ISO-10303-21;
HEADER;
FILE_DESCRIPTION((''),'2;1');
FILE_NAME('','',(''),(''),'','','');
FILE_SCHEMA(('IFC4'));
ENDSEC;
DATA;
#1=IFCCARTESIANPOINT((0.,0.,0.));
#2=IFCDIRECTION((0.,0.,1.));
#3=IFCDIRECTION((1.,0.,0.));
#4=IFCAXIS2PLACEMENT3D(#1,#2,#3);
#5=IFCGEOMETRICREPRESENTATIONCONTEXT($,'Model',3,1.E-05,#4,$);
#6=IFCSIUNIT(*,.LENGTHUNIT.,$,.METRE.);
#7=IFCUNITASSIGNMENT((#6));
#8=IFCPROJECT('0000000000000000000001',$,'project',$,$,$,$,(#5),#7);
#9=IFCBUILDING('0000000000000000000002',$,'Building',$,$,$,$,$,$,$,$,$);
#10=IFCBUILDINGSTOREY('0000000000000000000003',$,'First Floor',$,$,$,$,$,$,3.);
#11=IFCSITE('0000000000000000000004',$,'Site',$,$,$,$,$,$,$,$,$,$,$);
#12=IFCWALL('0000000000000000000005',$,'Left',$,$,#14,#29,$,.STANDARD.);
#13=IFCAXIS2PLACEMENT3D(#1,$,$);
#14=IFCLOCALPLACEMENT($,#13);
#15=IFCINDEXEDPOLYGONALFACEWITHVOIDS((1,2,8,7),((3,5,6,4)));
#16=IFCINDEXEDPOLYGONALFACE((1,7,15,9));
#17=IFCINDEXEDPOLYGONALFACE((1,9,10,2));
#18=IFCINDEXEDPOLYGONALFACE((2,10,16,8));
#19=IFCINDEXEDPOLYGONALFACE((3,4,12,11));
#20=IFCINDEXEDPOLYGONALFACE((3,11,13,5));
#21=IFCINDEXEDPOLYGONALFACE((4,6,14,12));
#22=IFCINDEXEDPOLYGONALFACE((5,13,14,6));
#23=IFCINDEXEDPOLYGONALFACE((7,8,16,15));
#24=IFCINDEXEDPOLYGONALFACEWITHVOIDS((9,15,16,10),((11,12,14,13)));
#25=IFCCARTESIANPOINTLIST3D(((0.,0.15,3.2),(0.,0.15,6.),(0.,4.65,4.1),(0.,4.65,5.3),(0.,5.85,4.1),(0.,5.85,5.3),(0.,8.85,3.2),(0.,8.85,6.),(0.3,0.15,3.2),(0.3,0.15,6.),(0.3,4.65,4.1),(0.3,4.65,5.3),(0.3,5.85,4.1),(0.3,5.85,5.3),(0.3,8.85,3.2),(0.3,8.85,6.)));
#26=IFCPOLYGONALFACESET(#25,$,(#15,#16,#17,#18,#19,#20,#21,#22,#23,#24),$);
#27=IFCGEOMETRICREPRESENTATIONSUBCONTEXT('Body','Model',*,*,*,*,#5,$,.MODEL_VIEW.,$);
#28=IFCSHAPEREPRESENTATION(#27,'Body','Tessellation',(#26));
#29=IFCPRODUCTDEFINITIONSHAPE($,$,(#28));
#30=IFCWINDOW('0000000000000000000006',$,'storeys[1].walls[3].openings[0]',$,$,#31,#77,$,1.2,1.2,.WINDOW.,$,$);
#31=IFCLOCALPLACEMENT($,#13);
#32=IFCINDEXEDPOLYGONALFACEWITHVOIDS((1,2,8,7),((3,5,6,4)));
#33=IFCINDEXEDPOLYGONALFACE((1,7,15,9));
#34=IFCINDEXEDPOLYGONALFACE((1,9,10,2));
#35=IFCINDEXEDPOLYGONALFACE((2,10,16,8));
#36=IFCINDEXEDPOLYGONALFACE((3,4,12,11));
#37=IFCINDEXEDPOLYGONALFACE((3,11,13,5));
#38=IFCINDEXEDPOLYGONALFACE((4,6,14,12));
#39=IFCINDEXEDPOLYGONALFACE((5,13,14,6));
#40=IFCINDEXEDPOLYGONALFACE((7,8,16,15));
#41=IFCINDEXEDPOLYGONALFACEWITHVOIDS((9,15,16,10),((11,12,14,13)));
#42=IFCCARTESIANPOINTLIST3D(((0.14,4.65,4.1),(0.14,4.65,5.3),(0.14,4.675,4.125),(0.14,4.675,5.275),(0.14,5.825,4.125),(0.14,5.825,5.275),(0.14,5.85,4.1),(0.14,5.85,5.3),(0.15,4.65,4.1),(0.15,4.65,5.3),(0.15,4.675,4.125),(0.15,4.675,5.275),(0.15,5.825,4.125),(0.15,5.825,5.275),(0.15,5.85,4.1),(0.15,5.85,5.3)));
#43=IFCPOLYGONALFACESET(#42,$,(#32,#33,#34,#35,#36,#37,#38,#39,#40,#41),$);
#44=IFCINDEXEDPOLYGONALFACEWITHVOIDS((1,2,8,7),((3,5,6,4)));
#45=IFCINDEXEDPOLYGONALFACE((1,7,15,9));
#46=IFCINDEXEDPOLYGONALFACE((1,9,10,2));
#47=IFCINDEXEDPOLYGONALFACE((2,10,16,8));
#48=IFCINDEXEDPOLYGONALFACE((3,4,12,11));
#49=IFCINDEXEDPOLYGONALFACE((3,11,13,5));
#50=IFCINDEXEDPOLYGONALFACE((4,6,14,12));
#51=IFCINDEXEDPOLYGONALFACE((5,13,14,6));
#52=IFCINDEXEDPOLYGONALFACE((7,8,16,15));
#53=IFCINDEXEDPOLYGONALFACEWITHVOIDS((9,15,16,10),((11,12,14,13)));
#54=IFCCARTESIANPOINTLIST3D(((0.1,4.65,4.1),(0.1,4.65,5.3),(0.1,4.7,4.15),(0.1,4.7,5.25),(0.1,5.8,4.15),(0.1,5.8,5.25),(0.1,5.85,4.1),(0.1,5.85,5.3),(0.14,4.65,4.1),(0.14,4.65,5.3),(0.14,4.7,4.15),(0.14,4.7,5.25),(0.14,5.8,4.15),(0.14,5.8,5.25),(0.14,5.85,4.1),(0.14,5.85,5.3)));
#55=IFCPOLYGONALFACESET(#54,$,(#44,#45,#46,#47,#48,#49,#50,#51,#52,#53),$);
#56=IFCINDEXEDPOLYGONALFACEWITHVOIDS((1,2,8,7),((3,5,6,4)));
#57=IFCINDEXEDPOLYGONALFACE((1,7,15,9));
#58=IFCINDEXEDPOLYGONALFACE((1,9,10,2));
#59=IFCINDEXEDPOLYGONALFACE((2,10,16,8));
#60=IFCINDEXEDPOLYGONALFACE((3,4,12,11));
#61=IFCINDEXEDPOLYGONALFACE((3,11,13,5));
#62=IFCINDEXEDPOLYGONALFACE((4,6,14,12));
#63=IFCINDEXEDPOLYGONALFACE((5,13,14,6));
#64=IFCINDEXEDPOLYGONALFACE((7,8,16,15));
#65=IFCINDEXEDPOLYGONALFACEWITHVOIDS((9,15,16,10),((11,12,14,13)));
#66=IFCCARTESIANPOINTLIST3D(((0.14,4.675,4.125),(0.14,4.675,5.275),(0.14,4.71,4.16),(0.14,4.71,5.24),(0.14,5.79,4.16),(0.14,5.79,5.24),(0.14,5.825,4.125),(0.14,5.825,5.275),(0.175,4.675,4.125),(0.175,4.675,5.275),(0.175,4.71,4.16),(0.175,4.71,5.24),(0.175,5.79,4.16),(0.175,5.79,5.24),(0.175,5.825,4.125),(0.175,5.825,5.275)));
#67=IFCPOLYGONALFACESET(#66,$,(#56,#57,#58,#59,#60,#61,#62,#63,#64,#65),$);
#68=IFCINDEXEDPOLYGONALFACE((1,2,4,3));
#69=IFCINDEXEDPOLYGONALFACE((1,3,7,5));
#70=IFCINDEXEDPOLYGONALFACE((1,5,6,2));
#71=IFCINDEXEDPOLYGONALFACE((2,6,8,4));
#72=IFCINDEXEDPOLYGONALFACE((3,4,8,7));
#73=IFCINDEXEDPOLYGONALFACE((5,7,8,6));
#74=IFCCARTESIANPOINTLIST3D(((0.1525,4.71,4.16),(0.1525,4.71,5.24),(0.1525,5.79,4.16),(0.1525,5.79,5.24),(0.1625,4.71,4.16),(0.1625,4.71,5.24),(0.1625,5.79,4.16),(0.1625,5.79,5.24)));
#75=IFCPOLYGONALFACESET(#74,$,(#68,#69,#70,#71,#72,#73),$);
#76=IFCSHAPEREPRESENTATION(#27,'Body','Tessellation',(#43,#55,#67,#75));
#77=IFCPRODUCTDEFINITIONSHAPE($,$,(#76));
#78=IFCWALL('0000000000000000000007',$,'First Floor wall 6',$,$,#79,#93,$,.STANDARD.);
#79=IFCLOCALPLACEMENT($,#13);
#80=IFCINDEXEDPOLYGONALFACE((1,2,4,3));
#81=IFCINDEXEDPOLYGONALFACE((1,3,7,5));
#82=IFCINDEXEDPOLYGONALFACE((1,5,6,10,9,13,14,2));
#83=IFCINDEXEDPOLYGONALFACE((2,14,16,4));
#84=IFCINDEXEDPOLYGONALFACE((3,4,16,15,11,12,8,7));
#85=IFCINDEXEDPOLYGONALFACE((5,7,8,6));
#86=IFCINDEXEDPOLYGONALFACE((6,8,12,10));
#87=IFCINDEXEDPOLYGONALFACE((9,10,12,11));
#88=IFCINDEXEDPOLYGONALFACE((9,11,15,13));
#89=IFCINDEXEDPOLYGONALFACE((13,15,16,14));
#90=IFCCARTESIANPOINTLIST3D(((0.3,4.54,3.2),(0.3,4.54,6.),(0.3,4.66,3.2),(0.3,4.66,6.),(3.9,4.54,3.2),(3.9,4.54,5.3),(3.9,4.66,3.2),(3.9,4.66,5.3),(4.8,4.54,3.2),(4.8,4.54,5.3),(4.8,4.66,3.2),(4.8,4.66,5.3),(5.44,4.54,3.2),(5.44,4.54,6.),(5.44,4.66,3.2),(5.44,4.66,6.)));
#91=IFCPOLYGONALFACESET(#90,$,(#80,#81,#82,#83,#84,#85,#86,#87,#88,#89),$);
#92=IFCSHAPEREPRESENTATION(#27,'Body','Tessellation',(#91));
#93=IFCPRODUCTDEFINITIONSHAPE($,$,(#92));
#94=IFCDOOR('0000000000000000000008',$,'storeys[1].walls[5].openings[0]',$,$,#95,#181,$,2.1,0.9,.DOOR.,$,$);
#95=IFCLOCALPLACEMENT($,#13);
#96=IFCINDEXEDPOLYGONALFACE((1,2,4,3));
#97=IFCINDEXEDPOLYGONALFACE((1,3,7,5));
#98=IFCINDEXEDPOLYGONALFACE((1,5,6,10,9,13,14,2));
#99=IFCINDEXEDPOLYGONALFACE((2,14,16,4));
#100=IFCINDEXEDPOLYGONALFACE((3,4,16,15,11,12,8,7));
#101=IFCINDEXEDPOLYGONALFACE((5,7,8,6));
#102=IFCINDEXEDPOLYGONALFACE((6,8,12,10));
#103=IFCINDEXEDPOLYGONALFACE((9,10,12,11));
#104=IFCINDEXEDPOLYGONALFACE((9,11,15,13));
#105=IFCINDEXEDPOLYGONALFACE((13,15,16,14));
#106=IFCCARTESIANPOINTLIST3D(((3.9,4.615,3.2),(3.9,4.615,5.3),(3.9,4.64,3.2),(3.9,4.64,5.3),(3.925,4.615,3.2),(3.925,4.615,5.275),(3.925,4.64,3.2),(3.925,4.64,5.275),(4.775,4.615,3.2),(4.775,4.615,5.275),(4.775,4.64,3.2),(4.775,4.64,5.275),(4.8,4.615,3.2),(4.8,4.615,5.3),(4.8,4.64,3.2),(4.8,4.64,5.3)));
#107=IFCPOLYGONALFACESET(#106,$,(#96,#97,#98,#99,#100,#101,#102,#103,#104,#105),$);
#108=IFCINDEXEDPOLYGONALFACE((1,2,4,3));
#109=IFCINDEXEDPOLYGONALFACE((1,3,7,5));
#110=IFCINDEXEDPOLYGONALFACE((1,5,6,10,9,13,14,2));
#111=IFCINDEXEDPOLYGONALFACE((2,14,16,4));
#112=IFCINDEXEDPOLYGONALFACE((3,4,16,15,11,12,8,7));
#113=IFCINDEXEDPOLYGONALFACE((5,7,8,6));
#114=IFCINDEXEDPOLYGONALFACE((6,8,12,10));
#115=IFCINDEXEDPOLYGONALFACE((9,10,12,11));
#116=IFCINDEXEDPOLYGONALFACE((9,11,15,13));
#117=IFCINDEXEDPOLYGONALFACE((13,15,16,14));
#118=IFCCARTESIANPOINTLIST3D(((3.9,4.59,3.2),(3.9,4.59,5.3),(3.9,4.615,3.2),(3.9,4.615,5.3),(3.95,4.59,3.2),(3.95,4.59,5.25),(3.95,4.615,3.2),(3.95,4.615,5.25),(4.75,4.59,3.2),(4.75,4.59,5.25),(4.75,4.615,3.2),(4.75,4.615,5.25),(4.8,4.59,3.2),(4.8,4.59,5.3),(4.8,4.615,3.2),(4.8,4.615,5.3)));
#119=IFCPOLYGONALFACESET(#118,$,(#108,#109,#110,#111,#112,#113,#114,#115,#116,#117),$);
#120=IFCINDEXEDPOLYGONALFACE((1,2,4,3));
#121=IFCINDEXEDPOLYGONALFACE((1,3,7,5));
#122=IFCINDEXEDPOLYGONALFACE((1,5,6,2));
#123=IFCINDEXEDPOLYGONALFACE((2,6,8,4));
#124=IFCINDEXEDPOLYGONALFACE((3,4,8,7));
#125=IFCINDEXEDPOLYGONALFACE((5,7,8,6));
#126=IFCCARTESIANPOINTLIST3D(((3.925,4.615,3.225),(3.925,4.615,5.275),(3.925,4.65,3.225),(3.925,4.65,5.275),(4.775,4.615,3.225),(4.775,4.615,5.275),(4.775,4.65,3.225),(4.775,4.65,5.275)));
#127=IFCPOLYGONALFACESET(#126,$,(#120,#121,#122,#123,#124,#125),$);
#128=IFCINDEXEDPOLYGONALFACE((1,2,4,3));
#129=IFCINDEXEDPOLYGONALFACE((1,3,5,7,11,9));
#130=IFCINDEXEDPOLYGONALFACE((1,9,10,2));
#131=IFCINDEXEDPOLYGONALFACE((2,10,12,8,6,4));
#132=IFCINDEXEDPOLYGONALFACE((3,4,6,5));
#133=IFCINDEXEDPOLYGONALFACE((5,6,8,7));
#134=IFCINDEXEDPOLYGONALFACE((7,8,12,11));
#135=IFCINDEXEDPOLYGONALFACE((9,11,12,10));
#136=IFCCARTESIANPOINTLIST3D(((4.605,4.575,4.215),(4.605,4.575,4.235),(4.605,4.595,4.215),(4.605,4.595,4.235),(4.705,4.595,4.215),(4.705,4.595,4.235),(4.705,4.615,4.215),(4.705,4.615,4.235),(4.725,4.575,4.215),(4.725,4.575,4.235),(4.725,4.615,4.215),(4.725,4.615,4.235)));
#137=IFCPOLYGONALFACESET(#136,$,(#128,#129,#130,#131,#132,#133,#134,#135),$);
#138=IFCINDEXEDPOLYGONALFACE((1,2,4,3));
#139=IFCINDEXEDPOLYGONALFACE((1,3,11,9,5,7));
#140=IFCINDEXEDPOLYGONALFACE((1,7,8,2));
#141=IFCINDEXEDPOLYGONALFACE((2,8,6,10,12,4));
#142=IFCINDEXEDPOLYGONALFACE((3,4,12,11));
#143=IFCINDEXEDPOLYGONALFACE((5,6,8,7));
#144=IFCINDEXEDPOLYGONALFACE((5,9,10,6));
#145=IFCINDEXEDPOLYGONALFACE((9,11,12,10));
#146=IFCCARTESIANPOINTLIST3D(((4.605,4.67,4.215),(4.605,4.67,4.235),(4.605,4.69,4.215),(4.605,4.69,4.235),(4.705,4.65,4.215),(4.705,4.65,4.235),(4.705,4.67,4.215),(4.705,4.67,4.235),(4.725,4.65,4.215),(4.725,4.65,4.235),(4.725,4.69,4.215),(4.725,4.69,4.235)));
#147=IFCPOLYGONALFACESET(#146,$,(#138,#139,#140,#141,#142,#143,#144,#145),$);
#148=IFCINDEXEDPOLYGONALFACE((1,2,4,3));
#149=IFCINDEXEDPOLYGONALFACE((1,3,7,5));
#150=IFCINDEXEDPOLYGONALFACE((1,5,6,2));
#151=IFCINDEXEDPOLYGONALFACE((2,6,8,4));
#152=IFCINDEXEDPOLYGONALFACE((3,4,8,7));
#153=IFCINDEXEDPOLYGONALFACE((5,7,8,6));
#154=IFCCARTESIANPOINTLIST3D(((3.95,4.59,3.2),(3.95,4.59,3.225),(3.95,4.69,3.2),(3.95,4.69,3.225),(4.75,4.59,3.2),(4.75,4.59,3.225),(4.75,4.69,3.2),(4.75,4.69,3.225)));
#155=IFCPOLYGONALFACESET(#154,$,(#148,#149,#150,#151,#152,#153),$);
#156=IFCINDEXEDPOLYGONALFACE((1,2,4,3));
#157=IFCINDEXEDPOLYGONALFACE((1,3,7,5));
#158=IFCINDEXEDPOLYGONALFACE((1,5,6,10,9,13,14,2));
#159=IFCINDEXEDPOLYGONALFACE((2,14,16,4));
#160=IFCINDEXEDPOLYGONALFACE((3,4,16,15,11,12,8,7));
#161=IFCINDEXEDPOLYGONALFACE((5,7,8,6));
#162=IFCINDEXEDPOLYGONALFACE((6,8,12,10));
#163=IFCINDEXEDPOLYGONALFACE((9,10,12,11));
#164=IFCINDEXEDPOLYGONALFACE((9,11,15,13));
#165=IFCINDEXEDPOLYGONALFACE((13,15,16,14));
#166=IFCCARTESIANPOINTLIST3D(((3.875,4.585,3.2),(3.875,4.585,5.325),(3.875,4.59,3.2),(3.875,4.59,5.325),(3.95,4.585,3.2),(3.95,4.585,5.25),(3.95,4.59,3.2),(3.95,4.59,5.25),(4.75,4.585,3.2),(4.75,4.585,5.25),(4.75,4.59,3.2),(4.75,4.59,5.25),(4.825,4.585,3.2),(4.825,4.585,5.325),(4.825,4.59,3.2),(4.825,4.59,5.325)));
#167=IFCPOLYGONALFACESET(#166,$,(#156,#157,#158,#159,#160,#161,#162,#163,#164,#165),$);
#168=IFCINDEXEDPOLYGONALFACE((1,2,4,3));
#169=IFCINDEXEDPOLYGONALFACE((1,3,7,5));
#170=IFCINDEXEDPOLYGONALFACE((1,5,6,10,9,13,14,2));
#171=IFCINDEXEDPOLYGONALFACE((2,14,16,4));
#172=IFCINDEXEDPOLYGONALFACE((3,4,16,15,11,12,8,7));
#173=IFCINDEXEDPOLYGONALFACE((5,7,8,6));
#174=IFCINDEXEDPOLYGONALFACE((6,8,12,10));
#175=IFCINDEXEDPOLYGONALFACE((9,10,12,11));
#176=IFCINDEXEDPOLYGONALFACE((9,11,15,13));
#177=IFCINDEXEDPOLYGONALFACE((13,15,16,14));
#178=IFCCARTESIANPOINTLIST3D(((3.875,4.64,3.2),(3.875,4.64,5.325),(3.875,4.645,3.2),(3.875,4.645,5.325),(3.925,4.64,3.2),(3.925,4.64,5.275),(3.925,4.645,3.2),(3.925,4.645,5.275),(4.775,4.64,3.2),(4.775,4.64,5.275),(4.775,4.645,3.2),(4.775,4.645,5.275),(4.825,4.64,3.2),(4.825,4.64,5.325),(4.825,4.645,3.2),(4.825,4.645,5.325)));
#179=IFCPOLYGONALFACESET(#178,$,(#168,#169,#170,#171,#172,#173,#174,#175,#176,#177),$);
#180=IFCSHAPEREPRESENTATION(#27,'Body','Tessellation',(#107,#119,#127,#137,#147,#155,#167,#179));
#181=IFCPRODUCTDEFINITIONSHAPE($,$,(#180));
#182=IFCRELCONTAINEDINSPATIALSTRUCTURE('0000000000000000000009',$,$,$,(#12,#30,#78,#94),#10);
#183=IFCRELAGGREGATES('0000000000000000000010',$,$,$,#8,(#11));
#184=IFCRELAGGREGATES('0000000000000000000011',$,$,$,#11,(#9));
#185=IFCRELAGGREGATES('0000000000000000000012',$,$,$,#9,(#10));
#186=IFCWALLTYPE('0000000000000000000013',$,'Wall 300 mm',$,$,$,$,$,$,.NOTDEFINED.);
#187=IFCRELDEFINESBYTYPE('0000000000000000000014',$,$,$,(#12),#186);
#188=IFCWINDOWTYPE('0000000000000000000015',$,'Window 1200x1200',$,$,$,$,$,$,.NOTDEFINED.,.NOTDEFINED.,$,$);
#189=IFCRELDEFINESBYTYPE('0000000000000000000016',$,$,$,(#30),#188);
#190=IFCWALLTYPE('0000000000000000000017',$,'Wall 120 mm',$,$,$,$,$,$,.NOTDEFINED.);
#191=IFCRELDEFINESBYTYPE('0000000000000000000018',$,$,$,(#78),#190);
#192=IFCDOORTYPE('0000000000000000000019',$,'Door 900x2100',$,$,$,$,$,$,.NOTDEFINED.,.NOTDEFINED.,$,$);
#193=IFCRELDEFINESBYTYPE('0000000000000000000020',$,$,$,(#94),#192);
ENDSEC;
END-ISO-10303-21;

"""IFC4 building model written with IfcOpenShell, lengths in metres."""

from ifc_helpers import new_model, si_unit, frame, origin_with_axes, place, context, subcontext, project, spatial, line, indexed_curve, outline, extrude, type_object, element, fill, save


model = new_model("IFC4")

# Units and contexts
model_context = context("Model", 3, precision=1e-05, world=origin_with_axes())
body_context = subcontext(model_context, "Body", "Model", "MODEL_VIEW")
ifc_project = project(units=[si_unit("LENGTHUNIT", "METRE")], contexts=[model_context])

# Site, building, storey
site = spatial("IfcSite", under=ifc_project, Name="Site")
building = spatial("IfcBuilding", under=site, Name="Building")
storey = spatial("IfcBuildingStorey", under=building, Name="First Floor", Elevation=3.0)

# Shared definitions
wall_type_1 = type_object("IfcWallType", Name="Wall 300 mm", PredefinedType="NOTDEFINED")
window_type_1 = type_object("IfcWindowType", Name="Window 1200x1200", PartitioningType="NOTDEFINED", PredefinedType="NOTDEFINED")

# Wall, opening, window
wall_1_placement = place(None, frame((0.15, 8.85, 3.2), z_axis=(0.0, 0.0, 1.0), x_axis=(0.0, -1.0, 0.0)))
wall_1 = element("IfcWall", 1, at=wall_1_placement, inside=storey, type_object=wall_type_1, Name="Left", PredefinedType="STANDARD", context=body_context, shape_type="SweptSolid", body=[
    extrude(outline(indexed_curve([(0.0, 0.0), (0.0, 0.3), (8.7, 0.3), (8.7, 0.0), (0.0, 0.0)], self_intersect=False)), frame((0.0, -0.15, 0.0), z_axis=(0.0, 0.0, 1.0), x_axis=(1.0, 0.0, 0.0)), (0.0, 0.0, 1.0), 2.8),
])
opening_1_placement = place(wall_1_placement, frame((3.0, -0.16, 0.9), z_axis=(0.0, 0.0, 1.0), x_axis=(1.0, 0.0, 0.0)))
opening_1 = element("IfcOpeningElement", 2, at=opening_1_placement, cuts=wall_1, context=body_context, shape_type="SweptSolid", body=[
    extrude(outline(indexed_curve([(0.0, 0.0), (0.0, 0.32), (1.2, 0.32), (1.2, 0.0), (0.0, 0.0)], self_intersect=False)), origin_with_axes(), (0.0, 0.0, 1.0), 1.2),
])
window_1_placement = place(None, frame((0.05, 5.85, 4.1), z_axis=(0.0, 0.0, 1.0), x_axis=(0.0, -1.0, 0.0)))
window_1 = element("IfcWindow", 3, at=window_1_placement, inside=storey, type_object=window_type_1, Name="storeys[1].walls[3].openings[0]", OverallHeight=1.2, OverallWidth=1.2, PredefinedType="WINDOW", context=body_context, shape_type="SweptSolid", body=[
    extrude(outline(indexed_curve([(0.0, 0.0), (1.2, 0.0), (1.2, 1.2), (0.0, 1.2)], segments=[line(1, 2, 3, 4, 1)]), holes=[indexed_curve([(0.025, 0.025), (1.175, 0.025), (1.175, 1.175), (0.025, 1.175)], segments=[line(1, 2, 3, 4, 1)])]), frame((0.0, 0.09, 0.0), z_axis=(0.0, -1.0, 0.0), x_axis=(1.0, 0.0, 0.0)), (0.0, 0.0, -1.0), 0.01),
    extrude(outline(indexed_curve([(0.0, 0.0), (1.2, 0.0), (1.2, 1.2), (0.0, 1.2)], segments=[line(1, 2, 3, 4, 1)]), holes=[indexed_curve([(0.05, 0.05), (1.15, 0.05), (1.15, 1.15), (0.05, 1.15)], segments=[line(1, 2, 3, 4, 1)])]), frame((0.0, 0.05, 0.0), z_axis=(0.0, -1.0, 0.0), x_axis=(1.0, 0.0, 0.0)), (0.0, 0.0, -1.0), 0.04),
    extrude(outline(indexed_curve([(0.0, 0.0), (1.15, 0.0), (1.15, 1.15), (0.0, 1.15)], segments=[line(1, 2, 3, 4, 1)]), holes=[indexed_curve([(0.035, 0.035), (1.115, 0.035), (1.115, 1.115), (0.035, 1.115)], segments=[line(1, 2, 3, 4, 1)])]), frame((0.025, 0.09, 0.025), z_axis=(0.0, -1.0, 0.0), x_axis=(1.0, 0.0, 0.0)), (0.0, 0.0, -1.0), 0.035),
    extrude(outline(indexed_curve([(0.035, 0.035), (1.115, 0.035), (1.115, 1.115), (0.035, 1.115)], segments=[line(1, 2, 3, 4, 1)])), frame((0.025, 0.1025, 0.025), z_axis=(0.0, -1.0, 0.0), x_axis=(1.0, 0.0, 0.0)), (0.0, 0.0, -1.0), 0.01),
])
fill(opening_1, window_1)

# Shared definitions
wall_type_2 = type_object("IfcWallType", Name="Wall 120 mm", PredefinedType="NOTDEFINED")
door_type_1 = type_object("IfcDoorType", Name="Door 900x2100", OperationType="NOTDEFINED", PredefinedType="NOTDEFINED")

# Wall, opening, door
wall_2_placement = place(None, frame((0.3, 4.6, 3.2), z_axis=(0.0, 0.0, 1.0), x_axis=(1.0, 0.0, 0.0)))
wall_2 = element("IfcWall", 4, at=wall_2_placement, inside=storey, type_object=wall_type_2, Name="First Floor wall 6", PredefinedType="STANDARD", context=body_context, shape_type="SweptSolid", body=[
    extrude(outline(indexed_curve([(0.0, 0.0), (0.0, 0.12), (5.14, 0.12), (5.14, 0.0), (0.0, 0.0)], self_intersect=False)), frame((0.0, -0.06, 0.0), z_axis=(0.0, 0.0, 1.0), x_axis=(1.0, 0.0, 0.0)), (0.0, 0.0, 1.0), 2.8),
])
opening_2_placement = place(wall_2_placement, frame((3.6, -0.07, 0.0), z_axis=(0.0, 0.0, 1.0), x_axis=(1.0, 0.0, 0.0)))
opening_2 = element("IfcOpeningElement", 5, at=opening_2_placement, cuts=wall_2, context=body_context, shape_type="SweptSolid", body=[
    extrude(outline(indexed_curve([(0.0, 0.0), (0.0, 0.14), (0.9, 0.14), (0.9, 0.0), (0.0, 0.0)], self_intersect=False)), origin_with_axes(), (0.0, 0.0, 1.0), 2.1),
])
door_1_placement = place(None, frame((3.9, 4.59, 3.2), z_axis=(0.0, 0.0, 1.0), x_axis=(1.0, 0.0, 0.0)))
door_1 = element("IfcDoor", 6, at=door_1_placement, inside=storey, type_object=door_type_1, Name="storeys[1].walls[5].openings[0]", OverallHeight=2.1, OverallWidth=0.9, PredefinedType="DOOR", context=body_context, shape_type="SweptSolid", body=[
    extrude(outline(indexed_curve([(0.0, 0.0), (0.0, 2.1), (0.9, 2.1), (0.9, 0.0), (0.875, 0.0), (0.875, 2.075), (0.025, 2.075), (0.025, 0.0)], segments=[line(1, 2, 3, 4, 5, 6, 7, 8, 1)])), frame((0.0, 0.025, 0.0), z_axis=(0.0, -1.0, 0.0), x_axis=(1.0, 0.0, 0.0)), (0.0, 0.0, -1.0), 0.025),
    extrude(outline(indexed_curve([(0.0, 0.0), (0.0, 2.1), (0.9, 2.1), (0.9, 0.0), (0.85, 0.0), (0.85, 2.05), (0.05, 2.05), (0.05, 0.0)], segments=[line(1, 2, 3, 4, 5, 6, 7, 8, 1)])), frame((0.0, 0.0, 0.0), z_axis=(0.0, -1.0, 0.0), x_axis=(1.0, 0.0, 0.0)), (0.0, 0.0, -1.0), 0.025),
    extrude(outline(indexed_curve([(0.0, 0.0), (0.85, 0.0), (0.85, 0.035), (0.0, 0.035)], segments=[line(1, 2, 3, 4, 1)])), frame((0.025, 0.025, 0.025), z_axis=(0.0, 0.0, 1.0), x_axis=(1.0, 0.0, 0.0)), (0.0, 0.0, 1.0), 2.05),
    extrude(outline(indexed_curve([(0.0, 0.0), (0.0, -0.04), (-0.12, -0.04), (-0.12, -0.02), (-0.02, -0.02), (-0.02, 0.0)], segments=[line(1, 2, 3, 4, 5, 6, 1)])), frame((0.825, 0.025, 1.015), z_axis=(0.0, 0.0, 1.0), x_axis=(1.0, 0.0, 0.0)), (0.0, 0.0, 1.0), 0.02),
    extrude(outline(indexed_curve([(0.0, 0.0), (0.0, 0.04), (-0.12, 0.04), (-0.12, 0.02), (-0.02, 0.02), (-0.02, 0.0)], segments=[line(1, 2, 3, 4, 5, 6, 1)])), frame((0.825, 0.06, 1.015), z_axis=(0.0, 0.0, 1.0), x_axis=(1.0, 0.0, 0.0)), (0.0, 0.0, 1.0), 0.02),
    extrude(outline(indexed_curve([(0.0, 0.0), (0.8, 0.0), (0.8, 0.1), (0.0, 0.1)], segments=[line(1, 2, 3, 4, 1)])), frame((0.05, 0.0, 0.0), z_axis=(0.0, 0.0, 1.0), x_axis=(1.0, 0.0, 0.0)), (0.0, 0.0, 1.0), 0.025),
    extrude(outline(indexed_curve([(0.0, 0.0), (0.0, 2.125), (0.95, 2.125), (0.95, 0.0), (0.875, 0.0), (0.875, 2.05), (0.075, 2.05), (0.075, 0.0)], segments=[line(1, 2, 3, 4, 5, 6, 7, 8, 1)])), frame((-0.025, -0.005, 0.0), z_axis=(0.0, -1.0, 0.0), x_axis=(1.0, 0.0, 0.0)), (0.0, 0.0, -1.0), 0.005),
    extrude(outline(indexed_curve([(0.0, 0.0), (0.0, 2.125), (0.95, 2.125), (0.95, 0.0), (0.9, 0.0), (0.9, 2.075), (0.05, 2.075), (0.05, 0.0)], segments=[line(1, 2, 3, 4, 5, 6, 7, 8, 1)])), frame((-0.025, 0.05, 0.0), z_axis=(0.0, -1.0, 0.0), x_axis=(1.0, 0.0, 0.0)), (0.0, 0.0, -1.0), 0.005),
])
fill(opening_2, door_1)

save(model, "model.ifc")
